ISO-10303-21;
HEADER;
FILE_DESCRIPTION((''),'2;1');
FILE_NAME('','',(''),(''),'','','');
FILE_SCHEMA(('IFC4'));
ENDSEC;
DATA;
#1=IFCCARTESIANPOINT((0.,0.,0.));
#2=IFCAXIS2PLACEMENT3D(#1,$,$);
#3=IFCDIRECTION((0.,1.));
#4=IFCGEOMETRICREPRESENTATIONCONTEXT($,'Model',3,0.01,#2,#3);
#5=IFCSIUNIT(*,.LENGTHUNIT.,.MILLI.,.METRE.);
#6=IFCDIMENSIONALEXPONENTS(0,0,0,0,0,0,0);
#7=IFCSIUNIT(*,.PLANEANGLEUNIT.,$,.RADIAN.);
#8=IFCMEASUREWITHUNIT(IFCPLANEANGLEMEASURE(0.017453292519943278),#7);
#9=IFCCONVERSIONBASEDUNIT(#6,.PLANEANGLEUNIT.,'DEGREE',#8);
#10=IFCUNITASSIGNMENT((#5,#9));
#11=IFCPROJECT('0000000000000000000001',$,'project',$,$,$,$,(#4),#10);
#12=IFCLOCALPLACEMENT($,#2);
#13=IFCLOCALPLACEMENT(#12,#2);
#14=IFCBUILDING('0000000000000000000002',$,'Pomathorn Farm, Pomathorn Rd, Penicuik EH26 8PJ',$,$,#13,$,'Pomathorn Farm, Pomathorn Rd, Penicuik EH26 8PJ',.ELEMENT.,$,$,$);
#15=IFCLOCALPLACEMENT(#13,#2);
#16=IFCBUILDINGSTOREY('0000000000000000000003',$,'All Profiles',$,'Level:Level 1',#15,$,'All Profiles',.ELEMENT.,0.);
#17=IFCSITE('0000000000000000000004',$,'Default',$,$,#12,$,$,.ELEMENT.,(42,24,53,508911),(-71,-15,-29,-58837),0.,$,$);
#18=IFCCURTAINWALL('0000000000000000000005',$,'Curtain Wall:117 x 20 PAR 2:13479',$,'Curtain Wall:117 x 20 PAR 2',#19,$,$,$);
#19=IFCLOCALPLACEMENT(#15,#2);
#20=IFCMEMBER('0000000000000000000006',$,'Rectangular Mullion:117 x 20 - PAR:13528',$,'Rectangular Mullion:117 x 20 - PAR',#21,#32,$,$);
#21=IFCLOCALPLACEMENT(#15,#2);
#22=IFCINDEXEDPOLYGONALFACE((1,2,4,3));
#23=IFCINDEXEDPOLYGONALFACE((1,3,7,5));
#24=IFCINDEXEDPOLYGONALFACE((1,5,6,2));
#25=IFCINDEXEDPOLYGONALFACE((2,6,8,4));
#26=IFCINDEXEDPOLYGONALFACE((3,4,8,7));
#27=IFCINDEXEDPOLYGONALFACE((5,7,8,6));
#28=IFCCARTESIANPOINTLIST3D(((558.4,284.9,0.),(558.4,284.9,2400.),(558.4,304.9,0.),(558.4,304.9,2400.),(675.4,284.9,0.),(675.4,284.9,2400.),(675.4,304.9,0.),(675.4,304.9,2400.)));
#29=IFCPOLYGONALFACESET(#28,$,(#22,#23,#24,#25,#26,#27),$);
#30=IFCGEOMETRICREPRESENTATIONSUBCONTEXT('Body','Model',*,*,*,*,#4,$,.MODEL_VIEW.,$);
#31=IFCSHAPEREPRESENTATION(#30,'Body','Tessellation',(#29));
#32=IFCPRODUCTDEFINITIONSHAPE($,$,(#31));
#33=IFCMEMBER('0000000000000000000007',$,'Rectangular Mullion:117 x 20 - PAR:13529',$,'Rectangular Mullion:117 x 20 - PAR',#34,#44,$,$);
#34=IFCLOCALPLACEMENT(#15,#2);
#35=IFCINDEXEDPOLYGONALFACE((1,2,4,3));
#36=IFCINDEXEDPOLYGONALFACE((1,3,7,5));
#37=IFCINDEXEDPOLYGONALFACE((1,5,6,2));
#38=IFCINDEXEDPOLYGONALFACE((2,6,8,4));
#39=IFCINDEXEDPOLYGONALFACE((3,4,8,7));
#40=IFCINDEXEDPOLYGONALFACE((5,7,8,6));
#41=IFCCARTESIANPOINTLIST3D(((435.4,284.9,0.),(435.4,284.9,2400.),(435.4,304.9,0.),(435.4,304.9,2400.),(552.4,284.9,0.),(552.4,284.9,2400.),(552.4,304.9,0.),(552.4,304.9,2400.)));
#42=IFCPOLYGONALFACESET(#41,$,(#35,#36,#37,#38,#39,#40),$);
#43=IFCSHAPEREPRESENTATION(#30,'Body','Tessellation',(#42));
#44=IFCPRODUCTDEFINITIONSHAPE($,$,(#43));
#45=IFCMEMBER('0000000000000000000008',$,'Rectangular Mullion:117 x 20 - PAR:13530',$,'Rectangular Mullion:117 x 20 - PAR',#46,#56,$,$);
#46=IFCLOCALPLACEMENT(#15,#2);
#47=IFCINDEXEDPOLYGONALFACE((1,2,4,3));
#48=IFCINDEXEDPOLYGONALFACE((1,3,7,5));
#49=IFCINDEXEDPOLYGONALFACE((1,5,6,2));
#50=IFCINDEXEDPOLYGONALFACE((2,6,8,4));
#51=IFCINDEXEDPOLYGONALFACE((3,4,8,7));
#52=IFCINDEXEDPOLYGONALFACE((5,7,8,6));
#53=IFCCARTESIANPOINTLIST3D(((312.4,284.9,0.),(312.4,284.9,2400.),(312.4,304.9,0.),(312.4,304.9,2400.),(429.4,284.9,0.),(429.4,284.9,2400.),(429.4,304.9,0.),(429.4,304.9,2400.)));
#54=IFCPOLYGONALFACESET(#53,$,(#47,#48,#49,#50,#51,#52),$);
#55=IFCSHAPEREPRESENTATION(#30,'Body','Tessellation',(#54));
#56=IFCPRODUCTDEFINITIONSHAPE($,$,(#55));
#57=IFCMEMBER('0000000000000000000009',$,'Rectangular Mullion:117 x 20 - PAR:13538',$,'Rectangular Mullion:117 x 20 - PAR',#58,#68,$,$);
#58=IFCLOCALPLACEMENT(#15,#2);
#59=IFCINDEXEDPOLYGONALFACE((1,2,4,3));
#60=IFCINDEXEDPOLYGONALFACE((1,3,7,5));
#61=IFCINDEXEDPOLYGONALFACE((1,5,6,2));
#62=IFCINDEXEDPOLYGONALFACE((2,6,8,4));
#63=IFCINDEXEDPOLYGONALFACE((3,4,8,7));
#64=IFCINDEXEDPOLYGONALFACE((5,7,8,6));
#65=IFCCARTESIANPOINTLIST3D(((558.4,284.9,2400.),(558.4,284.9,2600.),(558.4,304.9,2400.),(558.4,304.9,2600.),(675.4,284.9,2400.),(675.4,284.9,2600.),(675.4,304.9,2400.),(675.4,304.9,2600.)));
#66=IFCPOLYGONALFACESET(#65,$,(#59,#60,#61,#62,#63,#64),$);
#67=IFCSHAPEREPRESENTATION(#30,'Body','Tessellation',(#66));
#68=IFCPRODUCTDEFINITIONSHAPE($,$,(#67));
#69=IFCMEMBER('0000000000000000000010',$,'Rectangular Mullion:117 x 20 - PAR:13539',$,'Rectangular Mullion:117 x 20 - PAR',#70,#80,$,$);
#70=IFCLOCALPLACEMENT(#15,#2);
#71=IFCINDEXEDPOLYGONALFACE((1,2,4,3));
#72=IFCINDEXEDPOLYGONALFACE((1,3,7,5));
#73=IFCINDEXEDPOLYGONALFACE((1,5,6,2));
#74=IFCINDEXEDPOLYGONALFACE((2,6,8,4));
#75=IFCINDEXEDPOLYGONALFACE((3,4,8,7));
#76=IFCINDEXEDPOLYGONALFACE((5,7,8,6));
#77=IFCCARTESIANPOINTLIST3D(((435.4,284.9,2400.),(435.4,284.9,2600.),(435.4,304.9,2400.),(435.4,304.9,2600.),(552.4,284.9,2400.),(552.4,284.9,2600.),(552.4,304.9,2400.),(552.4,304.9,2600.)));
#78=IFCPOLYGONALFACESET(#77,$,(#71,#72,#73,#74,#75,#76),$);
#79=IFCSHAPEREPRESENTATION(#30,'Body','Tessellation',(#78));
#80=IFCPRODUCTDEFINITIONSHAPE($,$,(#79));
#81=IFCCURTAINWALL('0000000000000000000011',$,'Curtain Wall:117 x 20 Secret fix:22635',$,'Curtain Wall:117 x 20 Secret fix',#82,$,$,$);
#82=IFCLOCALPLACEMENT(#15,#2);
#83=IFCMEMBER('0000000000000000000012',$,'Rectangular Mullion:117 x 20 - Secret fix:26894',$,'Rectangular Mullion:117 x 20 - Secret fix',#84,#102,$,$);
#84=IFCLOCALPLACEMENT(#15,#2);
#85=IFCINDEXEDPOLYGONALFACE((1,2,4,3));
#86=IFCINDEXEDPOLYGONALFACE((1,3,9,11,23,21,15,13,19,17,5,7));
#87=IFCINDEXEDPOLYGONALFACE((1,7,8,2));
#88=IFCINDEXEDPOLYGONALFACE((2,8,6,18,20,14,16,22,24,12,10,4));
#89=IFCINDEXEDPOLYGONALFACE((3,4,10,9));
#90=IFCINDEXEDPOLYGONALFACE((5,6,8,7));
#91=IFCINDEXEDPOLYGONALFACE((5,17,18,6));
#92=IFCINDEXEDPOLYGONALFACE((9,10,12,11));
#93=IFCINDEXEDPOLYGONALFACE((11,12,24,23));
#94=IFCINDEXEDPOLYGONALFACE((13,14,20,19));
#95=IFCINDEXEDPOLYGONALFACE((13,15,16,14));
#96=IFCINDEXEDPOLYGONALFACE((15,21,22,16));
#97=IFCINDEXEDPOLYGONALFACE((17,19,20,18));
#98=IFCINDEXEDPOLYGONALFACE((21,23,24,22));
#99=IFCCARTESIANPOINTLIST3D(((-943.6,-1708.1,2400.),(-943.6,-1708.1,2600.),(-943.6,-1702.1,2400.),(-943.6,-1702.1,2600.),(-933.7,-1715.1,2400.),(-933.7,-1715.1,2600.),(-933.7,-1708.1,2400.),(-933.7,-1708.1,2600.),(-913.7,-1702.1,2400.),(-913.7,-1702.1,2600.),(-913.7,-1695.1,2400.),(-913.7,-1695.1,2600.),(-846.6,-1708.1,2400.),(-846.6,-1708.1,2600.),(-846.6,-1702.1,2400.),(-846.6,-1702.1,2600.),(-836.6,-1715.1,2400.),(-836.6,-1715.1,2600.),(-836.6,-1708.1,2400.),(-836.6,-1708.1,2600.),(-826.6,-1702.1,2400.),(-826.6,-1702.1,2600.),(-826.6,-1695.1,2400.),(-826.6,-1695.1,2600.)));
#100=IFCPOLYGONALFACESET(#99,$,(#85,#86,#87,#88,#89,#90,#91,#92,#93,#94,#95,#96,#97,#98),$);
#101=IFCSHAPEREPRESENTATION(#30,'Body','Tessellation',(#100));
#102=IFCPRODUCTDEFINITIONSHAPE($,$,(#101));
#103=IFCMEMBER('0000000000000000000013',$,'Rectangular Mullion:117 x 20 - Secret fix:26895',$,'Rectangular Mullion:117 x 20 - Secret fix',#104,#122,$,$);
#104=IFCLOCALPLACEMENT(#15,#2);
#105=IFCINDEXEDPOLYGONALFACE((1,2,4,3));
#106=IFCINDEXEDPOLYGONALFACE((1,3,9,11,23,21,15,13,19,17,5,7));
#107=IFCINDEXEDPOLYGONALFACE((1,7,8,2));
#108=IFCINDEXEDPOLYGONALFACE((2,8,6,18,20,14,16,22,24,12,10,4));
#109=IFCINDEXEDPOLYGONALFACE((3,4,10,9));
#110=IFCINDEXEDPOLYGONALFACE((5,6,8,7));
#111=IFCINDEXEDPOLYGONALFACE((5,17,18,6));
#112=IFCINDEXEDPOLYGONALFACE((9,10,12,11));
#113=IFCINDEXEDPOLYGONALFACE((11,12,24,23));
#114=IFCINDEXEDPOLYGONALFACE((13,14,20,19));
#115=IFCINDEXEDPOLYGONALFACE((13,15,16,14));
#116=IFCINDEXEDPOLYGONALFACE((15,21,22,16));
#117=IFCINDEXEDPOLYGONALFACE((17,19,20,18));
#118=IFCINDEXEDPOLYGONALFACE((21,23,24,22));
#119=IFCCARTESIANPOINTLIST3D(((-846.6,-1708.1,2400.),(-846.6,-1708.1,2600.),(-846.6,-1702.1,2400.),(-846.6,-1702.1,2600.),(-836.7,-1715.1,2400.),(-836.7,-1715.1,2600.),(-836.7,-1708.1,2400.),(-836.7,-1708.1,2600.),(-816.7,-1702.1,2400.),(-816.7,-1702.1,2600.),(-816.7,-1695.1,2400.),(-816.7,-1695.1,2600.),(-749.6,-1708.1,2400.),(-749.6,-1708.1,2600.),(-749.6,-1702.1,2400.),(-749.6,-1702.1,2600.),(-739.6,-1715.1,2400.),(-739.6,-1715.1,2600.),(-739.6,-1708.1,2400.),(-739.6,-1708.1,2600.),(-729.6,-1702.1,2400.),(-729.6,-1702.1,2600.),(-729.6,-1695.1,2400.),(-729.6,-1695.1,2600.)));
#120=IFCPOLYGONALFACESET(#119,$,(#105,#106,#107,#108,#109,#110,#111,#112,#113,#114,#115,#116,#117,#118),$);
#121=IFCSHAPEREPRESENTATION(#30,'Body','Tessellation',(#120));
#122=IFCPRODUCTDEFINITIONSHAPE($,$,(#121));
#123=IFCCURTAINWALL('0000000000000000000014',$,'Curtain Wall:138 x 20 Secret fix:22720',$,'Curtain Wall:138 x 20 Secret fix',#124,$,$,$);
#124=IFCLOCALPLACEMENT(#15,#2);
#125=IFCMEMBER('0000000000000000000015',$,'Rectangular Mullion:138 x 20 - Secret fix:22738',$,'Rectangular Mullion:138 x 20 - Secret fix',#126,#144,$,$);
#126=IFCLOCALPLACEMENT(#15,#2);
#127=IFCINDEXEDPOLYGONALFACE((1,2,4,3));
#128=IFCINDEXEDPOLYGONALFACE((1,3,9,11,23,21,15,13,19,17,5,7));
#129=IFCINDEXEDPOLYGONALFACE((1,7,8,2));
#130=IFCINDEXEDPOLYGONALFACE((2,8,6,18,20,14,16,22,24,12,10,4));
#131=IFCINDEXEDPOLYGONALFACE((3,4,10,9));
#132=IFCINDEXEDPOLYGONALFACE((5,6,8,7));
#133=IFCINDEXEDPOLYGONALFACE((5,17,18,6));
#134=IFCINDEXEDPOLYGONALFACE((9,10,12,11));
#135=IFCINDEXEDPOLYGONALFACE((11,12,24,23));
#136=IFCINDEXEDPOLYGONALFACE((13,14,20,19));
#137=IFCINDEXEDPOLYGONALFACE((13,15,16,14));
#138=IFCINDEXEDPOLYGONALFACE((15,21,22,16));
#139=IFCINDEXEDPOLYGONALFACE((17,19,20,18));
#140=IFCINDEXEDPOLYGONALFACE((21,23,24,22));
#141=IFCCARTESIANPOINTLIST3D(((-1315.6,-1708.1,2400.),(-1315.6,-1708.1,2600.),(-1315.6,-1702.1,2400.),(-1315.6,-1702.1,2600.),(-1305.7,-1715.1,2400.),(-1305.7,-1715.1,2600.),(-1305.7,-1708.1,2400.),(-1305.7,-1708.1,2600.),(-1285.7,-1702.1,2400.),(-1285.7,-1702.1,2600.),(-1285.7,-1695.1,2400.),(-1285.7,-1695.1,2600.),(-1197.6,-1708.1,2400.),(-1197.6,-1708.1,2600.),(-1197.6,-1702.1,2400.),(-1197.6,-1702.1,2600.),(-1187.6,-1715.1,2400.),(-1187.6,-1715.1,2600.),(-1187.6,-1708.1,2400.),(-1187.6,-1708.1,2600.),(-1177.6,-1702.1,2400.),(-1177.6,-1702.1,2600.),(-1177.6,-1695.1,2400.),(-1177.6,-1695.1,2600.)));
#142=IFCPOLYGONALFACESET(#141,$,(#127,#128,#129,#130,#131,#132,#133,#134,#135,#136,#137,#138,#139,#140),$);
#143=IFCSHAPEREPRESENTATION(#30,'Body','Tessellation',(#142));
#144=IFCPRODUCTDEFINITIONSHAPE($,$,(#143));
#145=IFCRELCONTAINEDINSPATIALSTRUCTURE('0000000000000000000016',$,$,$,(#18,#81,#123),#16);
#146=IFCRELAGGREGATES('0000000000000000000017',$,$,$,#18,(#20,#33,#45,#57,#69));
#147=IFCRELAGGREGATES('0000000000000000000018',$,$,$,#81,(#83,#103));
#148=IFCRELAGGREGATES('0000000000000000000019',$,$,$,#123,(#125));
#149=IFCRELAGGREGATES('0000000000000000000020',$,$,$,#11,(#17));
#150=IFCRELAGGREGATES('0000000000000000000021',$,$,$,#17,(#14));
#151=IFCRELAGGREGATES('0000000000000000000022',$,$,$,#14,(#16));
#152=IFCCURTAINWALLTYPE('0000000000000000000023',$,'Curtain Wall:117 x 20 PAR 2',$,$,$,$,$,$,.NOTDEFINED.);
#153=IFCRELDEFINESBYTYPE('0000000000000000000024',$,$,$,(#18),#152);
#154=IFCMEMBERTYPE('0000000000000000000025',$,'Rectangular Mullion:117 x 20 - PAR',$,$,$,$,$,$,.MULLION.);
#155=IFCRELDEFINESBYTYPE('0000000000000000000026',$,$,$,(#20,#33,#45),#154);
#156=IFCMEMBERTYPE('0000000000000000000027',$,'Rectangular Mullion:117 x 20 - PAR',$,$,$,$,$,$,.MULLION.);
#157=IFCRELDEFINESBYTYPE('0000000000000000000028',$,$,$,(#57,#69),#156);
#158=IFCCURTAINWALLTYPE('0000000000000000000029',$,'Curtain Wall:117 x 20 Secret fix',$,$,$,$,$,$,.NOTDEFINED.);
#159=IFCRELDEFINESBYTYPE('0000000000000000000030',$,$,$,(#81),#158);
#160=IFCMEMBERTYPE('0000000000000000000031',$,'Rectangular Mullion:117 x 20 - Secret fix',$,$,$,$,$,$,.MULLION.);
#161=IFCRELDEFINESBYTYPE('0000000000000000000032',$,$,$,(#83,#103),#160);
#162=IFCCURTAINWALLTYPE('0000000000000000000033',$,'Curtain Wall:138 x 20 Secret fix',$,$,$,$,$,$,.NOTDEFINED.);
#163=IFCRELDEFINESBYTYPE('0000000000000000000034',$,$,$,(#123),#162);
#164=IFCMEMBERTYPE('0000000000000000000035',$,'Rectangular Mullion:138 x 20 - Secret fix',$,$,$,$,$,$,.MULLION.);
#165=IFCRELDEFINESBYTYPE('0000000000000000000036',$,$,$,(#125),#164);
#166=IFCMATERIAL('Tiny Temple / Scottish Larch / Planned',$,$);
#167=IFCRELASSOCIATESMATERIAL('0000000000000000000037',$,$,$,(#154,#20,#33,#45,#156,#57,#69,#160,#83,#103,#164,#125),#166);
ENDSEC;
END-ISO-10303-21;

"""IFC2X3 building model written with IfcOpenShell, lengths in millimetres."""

from ifc_helpers import new_model, entity, si_unit, converted_unit, direction, frame, frame_2d, origin, place, context, subcontext, project, spatial, polyline, rectangle, outline, extrude, source, transform, mapped, material, type_object, type_shapes, element, aggregate, save


model = new_model("IFC2X3")

# Units and contexts
model_context = context("Model", 3, precision=0.01, world=origin(), true_north=direction((0.0, 1.0)))
body_context = subcontext(model_context, "Body", "Model", "MODEL_VIEW")
ifc_project = project(units=[si_unit("LENGTHUNIT", "METRE", prefix="MILLI"), converted_unit("PLANEANGLEUNIT", "DEGREE", entity("IfcPlaneAngleMeasure", 0.017453292519943278), si_unit("PLANEANGLEUNIT", "RADIAN"), dimensions=[0, 0, 0, 0, 0, 0, 0])], contexts=[model_context])

# Site, building, storey
site_placement = place(None, origin())
site = spatial("IfcSite", under=ifc_project, at=site_placement, Name="Default", CompositionType="ELEMENT", RefLatitude=(42, 24, 53, 508911), RefLongitude=(-71, -15, -29, -58837), RefElevation=0.0)
building_placement = place(site_placement, origin())
building = spatial("IfcBuilding", under=site, at=building_placement, Name="Pomathorn Farm, Pomathorn Rd, Penicuik EH26 8PJ", LongName="Pomathorn Farm, Pomathorn Rd, Penicuik EH26 8PJ", CompositionType="ELEMENT")
storey_placement = place(building_placement, origin())
storey = spatial("IfcBuildingStorey", under=building, at=storey_placement, Name="All Profiles", ObjectType="Level:Level 1", LongName="All Profiles", CompositionType="ELEMENT", Elevation=0.0)

# Curtain walls, members
curtain_wall_type_1 = type_object("IfcCurtainWallType", Name="Curtain Wall:117 x 20 PAR 2", PredefinedType="NOTDEFINED")
curtain_wall_1_placement = place(storey_placement, origin())
curtain_wall_1 = element("IfcCurtainWall", 1, at=curtain_wall_1_placement, inside=storey, type_object=curtain_wall_type_1, Name="Curtain Wall:117 x 20 PAR 2:13479", ObjectType="Curtain Wall:117 x 20 PAR 2")
ifc_material = material(Name="Tiny Temple / Scottish Larch / Planned")
member_type_1 = type_object("IfcMemberType", Name="Rectangular Mullion:117 x 20 - PAR", PredefinedType="MULLION", material=ifc_material)
shared_shape_1 = source(origin(), body_context, "Body", "SweptSolid", [
    extrude(rectangle(XDim=20.0, YDim=117.0, at=frame_2d((0.0, 0.0), x_axis=(1.0, 0.0))), frame((-58.5, -10.0, -2400.0), z_axis=(0.0, 0.0, 1.0), x_axis=(0.0, 1.0, 0.0)), (0.0, 0.0, 1.0), 2400.0),
])
type_shapes(member_type_1, [shared_shape_1])
member_1_placement = place(curtain_wall_1_placement, frame((675.4, 284.9, 0.0), z_axis=(0.0, 0.0, -1.0), x_axis=(1.0, 0.0, 0.0)))
member_1 = element("IfcMember", 2, at=member_1_placement, type_object=member_type_1, material=ifc_material, Name="Rectangular Mullion:117 x 20 - PAR:13528", ObjectType="Rectangular Mullion:117 x 20 - PAR", context=body_context, shape_type="MappedRepresentation", body=[
    mapped(shared_shape_1, transform((0.0, 0.0, 0.0), scale=1.0)),
])
member_2_placement = place(curtain_wall_1_placement, frame((552.4, 284.9, 0.0), z_axis=(0.0, 0.0, -1.0), x_axis=(1.0, 0.0, 0.0)))
member_2 = element("IfcMember", 3, at=member_2_placement, type_object=member_type_1, material=ifc_material, Name="Rectangular Mullion:117 x 20 - PAR:13529", ObjectType="Rectangular Mullion:117 x 20 - PAR", context=body_context, shape_type="MappedRepresentation", body=[
    mapped(shared_shape_1, transform((0.0, 0.0, 0.0), scale=1.0)),
])
member_3_placement = place(curtain_wall_1_placement, frame((429.4, 284.9, 0.0), z_axis=(0.0, 0.0, -1.0), x_axis=(1.0, 0.0, 0.0)))
member_3 = element("IfcMember", 4, at=member_3_placement, type_object=member_type_1, material=ifc_material, Name="Rectangular Mullion:117 x 20 - PAR:13530", ObjectType="Rectangular Mullion:117 x 20 - PAR", context=body_context, shape_type="MappedRepresentation", body=[
    mapped(shared_shape_1, transform((0.0, 0.0, 0.0), scale=1.0)),
])
member_type_2 = type_object("IfcMemberType", Name="Rectangular Mullion:117 x 20 - PAR", PredefinedType="MULLION", material=ifc_material)
shared_shape_2 = source(origin(), body_context, "Body", "SweptSolid", [
    extrude(rectangle(XDim=20.0, YDim=117.0, at=frame_2d((0.0, 0.0), x_axis=(1.0, 0.0))), frame((-58.5, -10.0, -200.0), z_axis=(0.0, 0.0, 1.0), x_axis=(0.0, 1.0, 0.0)), (0.0, 0.0, 1.0), 200.0),
])
type_shapes(member_type_2, [shared_shape_2])
member_4_placement = place(curtain_wall_1_placement, frame((675.4, 284.9, 2400.0), z_axis=(0.0, 0.0, -1.0), x_axis=(1.0, 0.0, 0.0)))
member_4 = element("IfcMember", 5, at=member_4_placement, type_object=member_type_2, material=ifc_material, Name="Rectangular Mullion:117 x 20 - PAR:13538", ObjectType="Rectangular Mullion:117 x 20 - PAR", context=body_context, shape_type="MappedRepresentation", body=[
    mapped(shared_shape_2, transform((0.0, 0.0, 0.0), scale=1.0)),
])
member_5_placement = place(curtain_wall_1_placement, frame((552.4, 284.9, 2400.0), z_axis=(0.0, 0.0, -1.0), x_axis=(1.0, 0.0, 0.0)))
member_5 = element("IfcMember", 6, at=member_5_placement, type_object=member_type_2, material=ifc_material, Name="Rectangular Mullion:117 x 20 - PAR:13539", ObjectType="Rectangular Mullion:117 x 20 - PAR", context=body_context, shape_type="MappedRepresentation", body=[
    mapped(shared_shape_2, transform((0.0, 0.0, 0.0), scale=1.0)),
])
aggregate(curtain_wall_1, [member_1, member_2, member_3, member_4, member_5])
curtain_wall_type_2 = type_object("IfcCurtainWallType", Name="Curtain Wall:117 x 20 Secret fix", PredefinedType="NOTDEFINED")
curtain_wall_2_placement = place(storey_placement, origin())
curtain_wall_2 = element("IfcCurtainWall", 7, at=curtain_wall_2_placement, inside=storey, type_object=curtain_wall_type_2, Name="Curtain Wall:117 x 20 Secret fix:22635", ObjectType="Curtain Wall:117 x 20 Secret fix")
member_type_3 = type_object("IfcMemberType", Name="Rectangular Mullion:117 x 20 - Secret fix", PredefinedType="MULLION", material=ifc_material)
shared_shape_3 = source(origin(), body_context, "Body", "SweptSolid", [
    extrude(outline(polyline([(-3.0, -60.2), (3.0, -60.2), (3.0, -30.2), (10.0, -30.2), (10.0, 56.8), (3.0, 56.8), (3.0, 36.8), (-3.0, 36.8), (-3.0, 46.8), (-10.0, 46.8), (-10.0, -50.2), (-3.0, -50.2), (-3.0, -60.2)])), frame((-56.8, -10.0, -200.0), z_axis=(0.0, 0.0, 1.0), x_axis=(0.0, -1.0, 0.0)), (0.0, 0.0, 1.0), 200.0),
])
type_shapes(member_type_3, [shared_shape_3])
member_6_placement = place(curtain_wall_2_placement, frame((-826.6, -1715.1, 2400.0), z_axis=(0.0, 0.0, -1.0), x_axis=(1.0, 0.0, 0.0)))
member_6 = element("IfcMember", 8, at=member_6_placement, type_object=member_type_3, material=ifc_material, Name="Rectangular Mullion:117 x 20 - Secret fix:26894", ObjectType="Rectangular Mullion:117 x 20 - Secret fix", context=body_context, shape_type="MappedRepresentation", body=[
    mapped(shared_shape_3, transform((0.0, 0.0, 0.0), scale=1.0)),
])
member_7_placement = place(curtain_wall_2_placement, frame((-729.6, -1715.1, 2400.0), z_axis=(0.0, 0.0, -1.0), x_axis=(1.0, 0.0, 0.0)))
member_7 = element("IfcMember", 9, at=member_7_placement, type_object=member_type_3, material=ifc_material, Name="Rectangular Mullion:117 x 20 - Secret fix:26895", ObjectType="Rectangular Mullion:117 x 20 - Secret fix", context=body_context, shape_type="MappedRepresentation", body=[
    mapped(shared_shape_3, transform((0.0, 0.0, 0.0), scale=1.0)),
])
aggregate(curtain_wall_2, [member_6, member_7])

# Curtain wall, member
curtain_wall_type_3 = type_object("IfcCurtainWallType", Name="Curtain Wall:138 x 20 Secret fix", PredefinedType="NOTDEFINED")
curtain_wall_3_placement = place(storey_placement, origin())
curtain_wall_3 = element("IfcCurtainWall", 10, at=curtain_wall_3_placement, inside=storey, type_object=curtain_wall_type_3, Name="Curtain Wall:138 x 20 Secret fix:22720", ObjectType="Curtain Wall:138 x 20 Secret fix")
member_type_4 = type_object("IfcMemberType", Name="Rectangular Mullion:138 x 20 - Secret fix", PredefinedType="MULLION", material=ifc_material)
shared_shape_4 = source(origin(), body_context, "Body", "SweptSolid", [
    extrude(outline(polyline([(-3.0, -70.7), (3.0, -70.7), (3.0, -40.7), (10.0, -40.7), (10.0, 67.3), (3.0, 67.3), (3.0, 47.3), (-3.0, 47.3), (-3.0, 57.3), (-10.0, 57.3), (-10.0, -60.7), (-3.0, -60.7), (-3.0, -70.7)])), frame((-67.3, -10.0, -200.0), z_axis=(0.0, 0.0, 1.0), x_axis=(0.0, -1.0, 0.0)), (0.0, 0.0, 1.0), 200.0),
])
type_shapes(member_type_4, [shared_shape_4])
member_8_placement = place(curtain_wall_3_placement, frame((-1177.6, -1715.1, 2400.0), z_axis=(0.0, 0.0, -1.0), x_axis=(1.0, 0.0, 0.0)))
member_8 = element("IfcMember", 11, at=member_8_placement, type_object=member_type_4, material=ifc_material, Name="Rectangular Mullion:138 x 20 - Secret fix:22738", ObjectType="Rectangular Mullion:138 x 20 - Secret fix", context=body_context, shape_type="MappedRepresentation", body=[
    mapped(shared_shape_4, transform((0.0, 0.0, 0.0), scale=1.0)),
])
aggregate(curtain_wall_3, [member_8])

save(model, "model.ifc")
